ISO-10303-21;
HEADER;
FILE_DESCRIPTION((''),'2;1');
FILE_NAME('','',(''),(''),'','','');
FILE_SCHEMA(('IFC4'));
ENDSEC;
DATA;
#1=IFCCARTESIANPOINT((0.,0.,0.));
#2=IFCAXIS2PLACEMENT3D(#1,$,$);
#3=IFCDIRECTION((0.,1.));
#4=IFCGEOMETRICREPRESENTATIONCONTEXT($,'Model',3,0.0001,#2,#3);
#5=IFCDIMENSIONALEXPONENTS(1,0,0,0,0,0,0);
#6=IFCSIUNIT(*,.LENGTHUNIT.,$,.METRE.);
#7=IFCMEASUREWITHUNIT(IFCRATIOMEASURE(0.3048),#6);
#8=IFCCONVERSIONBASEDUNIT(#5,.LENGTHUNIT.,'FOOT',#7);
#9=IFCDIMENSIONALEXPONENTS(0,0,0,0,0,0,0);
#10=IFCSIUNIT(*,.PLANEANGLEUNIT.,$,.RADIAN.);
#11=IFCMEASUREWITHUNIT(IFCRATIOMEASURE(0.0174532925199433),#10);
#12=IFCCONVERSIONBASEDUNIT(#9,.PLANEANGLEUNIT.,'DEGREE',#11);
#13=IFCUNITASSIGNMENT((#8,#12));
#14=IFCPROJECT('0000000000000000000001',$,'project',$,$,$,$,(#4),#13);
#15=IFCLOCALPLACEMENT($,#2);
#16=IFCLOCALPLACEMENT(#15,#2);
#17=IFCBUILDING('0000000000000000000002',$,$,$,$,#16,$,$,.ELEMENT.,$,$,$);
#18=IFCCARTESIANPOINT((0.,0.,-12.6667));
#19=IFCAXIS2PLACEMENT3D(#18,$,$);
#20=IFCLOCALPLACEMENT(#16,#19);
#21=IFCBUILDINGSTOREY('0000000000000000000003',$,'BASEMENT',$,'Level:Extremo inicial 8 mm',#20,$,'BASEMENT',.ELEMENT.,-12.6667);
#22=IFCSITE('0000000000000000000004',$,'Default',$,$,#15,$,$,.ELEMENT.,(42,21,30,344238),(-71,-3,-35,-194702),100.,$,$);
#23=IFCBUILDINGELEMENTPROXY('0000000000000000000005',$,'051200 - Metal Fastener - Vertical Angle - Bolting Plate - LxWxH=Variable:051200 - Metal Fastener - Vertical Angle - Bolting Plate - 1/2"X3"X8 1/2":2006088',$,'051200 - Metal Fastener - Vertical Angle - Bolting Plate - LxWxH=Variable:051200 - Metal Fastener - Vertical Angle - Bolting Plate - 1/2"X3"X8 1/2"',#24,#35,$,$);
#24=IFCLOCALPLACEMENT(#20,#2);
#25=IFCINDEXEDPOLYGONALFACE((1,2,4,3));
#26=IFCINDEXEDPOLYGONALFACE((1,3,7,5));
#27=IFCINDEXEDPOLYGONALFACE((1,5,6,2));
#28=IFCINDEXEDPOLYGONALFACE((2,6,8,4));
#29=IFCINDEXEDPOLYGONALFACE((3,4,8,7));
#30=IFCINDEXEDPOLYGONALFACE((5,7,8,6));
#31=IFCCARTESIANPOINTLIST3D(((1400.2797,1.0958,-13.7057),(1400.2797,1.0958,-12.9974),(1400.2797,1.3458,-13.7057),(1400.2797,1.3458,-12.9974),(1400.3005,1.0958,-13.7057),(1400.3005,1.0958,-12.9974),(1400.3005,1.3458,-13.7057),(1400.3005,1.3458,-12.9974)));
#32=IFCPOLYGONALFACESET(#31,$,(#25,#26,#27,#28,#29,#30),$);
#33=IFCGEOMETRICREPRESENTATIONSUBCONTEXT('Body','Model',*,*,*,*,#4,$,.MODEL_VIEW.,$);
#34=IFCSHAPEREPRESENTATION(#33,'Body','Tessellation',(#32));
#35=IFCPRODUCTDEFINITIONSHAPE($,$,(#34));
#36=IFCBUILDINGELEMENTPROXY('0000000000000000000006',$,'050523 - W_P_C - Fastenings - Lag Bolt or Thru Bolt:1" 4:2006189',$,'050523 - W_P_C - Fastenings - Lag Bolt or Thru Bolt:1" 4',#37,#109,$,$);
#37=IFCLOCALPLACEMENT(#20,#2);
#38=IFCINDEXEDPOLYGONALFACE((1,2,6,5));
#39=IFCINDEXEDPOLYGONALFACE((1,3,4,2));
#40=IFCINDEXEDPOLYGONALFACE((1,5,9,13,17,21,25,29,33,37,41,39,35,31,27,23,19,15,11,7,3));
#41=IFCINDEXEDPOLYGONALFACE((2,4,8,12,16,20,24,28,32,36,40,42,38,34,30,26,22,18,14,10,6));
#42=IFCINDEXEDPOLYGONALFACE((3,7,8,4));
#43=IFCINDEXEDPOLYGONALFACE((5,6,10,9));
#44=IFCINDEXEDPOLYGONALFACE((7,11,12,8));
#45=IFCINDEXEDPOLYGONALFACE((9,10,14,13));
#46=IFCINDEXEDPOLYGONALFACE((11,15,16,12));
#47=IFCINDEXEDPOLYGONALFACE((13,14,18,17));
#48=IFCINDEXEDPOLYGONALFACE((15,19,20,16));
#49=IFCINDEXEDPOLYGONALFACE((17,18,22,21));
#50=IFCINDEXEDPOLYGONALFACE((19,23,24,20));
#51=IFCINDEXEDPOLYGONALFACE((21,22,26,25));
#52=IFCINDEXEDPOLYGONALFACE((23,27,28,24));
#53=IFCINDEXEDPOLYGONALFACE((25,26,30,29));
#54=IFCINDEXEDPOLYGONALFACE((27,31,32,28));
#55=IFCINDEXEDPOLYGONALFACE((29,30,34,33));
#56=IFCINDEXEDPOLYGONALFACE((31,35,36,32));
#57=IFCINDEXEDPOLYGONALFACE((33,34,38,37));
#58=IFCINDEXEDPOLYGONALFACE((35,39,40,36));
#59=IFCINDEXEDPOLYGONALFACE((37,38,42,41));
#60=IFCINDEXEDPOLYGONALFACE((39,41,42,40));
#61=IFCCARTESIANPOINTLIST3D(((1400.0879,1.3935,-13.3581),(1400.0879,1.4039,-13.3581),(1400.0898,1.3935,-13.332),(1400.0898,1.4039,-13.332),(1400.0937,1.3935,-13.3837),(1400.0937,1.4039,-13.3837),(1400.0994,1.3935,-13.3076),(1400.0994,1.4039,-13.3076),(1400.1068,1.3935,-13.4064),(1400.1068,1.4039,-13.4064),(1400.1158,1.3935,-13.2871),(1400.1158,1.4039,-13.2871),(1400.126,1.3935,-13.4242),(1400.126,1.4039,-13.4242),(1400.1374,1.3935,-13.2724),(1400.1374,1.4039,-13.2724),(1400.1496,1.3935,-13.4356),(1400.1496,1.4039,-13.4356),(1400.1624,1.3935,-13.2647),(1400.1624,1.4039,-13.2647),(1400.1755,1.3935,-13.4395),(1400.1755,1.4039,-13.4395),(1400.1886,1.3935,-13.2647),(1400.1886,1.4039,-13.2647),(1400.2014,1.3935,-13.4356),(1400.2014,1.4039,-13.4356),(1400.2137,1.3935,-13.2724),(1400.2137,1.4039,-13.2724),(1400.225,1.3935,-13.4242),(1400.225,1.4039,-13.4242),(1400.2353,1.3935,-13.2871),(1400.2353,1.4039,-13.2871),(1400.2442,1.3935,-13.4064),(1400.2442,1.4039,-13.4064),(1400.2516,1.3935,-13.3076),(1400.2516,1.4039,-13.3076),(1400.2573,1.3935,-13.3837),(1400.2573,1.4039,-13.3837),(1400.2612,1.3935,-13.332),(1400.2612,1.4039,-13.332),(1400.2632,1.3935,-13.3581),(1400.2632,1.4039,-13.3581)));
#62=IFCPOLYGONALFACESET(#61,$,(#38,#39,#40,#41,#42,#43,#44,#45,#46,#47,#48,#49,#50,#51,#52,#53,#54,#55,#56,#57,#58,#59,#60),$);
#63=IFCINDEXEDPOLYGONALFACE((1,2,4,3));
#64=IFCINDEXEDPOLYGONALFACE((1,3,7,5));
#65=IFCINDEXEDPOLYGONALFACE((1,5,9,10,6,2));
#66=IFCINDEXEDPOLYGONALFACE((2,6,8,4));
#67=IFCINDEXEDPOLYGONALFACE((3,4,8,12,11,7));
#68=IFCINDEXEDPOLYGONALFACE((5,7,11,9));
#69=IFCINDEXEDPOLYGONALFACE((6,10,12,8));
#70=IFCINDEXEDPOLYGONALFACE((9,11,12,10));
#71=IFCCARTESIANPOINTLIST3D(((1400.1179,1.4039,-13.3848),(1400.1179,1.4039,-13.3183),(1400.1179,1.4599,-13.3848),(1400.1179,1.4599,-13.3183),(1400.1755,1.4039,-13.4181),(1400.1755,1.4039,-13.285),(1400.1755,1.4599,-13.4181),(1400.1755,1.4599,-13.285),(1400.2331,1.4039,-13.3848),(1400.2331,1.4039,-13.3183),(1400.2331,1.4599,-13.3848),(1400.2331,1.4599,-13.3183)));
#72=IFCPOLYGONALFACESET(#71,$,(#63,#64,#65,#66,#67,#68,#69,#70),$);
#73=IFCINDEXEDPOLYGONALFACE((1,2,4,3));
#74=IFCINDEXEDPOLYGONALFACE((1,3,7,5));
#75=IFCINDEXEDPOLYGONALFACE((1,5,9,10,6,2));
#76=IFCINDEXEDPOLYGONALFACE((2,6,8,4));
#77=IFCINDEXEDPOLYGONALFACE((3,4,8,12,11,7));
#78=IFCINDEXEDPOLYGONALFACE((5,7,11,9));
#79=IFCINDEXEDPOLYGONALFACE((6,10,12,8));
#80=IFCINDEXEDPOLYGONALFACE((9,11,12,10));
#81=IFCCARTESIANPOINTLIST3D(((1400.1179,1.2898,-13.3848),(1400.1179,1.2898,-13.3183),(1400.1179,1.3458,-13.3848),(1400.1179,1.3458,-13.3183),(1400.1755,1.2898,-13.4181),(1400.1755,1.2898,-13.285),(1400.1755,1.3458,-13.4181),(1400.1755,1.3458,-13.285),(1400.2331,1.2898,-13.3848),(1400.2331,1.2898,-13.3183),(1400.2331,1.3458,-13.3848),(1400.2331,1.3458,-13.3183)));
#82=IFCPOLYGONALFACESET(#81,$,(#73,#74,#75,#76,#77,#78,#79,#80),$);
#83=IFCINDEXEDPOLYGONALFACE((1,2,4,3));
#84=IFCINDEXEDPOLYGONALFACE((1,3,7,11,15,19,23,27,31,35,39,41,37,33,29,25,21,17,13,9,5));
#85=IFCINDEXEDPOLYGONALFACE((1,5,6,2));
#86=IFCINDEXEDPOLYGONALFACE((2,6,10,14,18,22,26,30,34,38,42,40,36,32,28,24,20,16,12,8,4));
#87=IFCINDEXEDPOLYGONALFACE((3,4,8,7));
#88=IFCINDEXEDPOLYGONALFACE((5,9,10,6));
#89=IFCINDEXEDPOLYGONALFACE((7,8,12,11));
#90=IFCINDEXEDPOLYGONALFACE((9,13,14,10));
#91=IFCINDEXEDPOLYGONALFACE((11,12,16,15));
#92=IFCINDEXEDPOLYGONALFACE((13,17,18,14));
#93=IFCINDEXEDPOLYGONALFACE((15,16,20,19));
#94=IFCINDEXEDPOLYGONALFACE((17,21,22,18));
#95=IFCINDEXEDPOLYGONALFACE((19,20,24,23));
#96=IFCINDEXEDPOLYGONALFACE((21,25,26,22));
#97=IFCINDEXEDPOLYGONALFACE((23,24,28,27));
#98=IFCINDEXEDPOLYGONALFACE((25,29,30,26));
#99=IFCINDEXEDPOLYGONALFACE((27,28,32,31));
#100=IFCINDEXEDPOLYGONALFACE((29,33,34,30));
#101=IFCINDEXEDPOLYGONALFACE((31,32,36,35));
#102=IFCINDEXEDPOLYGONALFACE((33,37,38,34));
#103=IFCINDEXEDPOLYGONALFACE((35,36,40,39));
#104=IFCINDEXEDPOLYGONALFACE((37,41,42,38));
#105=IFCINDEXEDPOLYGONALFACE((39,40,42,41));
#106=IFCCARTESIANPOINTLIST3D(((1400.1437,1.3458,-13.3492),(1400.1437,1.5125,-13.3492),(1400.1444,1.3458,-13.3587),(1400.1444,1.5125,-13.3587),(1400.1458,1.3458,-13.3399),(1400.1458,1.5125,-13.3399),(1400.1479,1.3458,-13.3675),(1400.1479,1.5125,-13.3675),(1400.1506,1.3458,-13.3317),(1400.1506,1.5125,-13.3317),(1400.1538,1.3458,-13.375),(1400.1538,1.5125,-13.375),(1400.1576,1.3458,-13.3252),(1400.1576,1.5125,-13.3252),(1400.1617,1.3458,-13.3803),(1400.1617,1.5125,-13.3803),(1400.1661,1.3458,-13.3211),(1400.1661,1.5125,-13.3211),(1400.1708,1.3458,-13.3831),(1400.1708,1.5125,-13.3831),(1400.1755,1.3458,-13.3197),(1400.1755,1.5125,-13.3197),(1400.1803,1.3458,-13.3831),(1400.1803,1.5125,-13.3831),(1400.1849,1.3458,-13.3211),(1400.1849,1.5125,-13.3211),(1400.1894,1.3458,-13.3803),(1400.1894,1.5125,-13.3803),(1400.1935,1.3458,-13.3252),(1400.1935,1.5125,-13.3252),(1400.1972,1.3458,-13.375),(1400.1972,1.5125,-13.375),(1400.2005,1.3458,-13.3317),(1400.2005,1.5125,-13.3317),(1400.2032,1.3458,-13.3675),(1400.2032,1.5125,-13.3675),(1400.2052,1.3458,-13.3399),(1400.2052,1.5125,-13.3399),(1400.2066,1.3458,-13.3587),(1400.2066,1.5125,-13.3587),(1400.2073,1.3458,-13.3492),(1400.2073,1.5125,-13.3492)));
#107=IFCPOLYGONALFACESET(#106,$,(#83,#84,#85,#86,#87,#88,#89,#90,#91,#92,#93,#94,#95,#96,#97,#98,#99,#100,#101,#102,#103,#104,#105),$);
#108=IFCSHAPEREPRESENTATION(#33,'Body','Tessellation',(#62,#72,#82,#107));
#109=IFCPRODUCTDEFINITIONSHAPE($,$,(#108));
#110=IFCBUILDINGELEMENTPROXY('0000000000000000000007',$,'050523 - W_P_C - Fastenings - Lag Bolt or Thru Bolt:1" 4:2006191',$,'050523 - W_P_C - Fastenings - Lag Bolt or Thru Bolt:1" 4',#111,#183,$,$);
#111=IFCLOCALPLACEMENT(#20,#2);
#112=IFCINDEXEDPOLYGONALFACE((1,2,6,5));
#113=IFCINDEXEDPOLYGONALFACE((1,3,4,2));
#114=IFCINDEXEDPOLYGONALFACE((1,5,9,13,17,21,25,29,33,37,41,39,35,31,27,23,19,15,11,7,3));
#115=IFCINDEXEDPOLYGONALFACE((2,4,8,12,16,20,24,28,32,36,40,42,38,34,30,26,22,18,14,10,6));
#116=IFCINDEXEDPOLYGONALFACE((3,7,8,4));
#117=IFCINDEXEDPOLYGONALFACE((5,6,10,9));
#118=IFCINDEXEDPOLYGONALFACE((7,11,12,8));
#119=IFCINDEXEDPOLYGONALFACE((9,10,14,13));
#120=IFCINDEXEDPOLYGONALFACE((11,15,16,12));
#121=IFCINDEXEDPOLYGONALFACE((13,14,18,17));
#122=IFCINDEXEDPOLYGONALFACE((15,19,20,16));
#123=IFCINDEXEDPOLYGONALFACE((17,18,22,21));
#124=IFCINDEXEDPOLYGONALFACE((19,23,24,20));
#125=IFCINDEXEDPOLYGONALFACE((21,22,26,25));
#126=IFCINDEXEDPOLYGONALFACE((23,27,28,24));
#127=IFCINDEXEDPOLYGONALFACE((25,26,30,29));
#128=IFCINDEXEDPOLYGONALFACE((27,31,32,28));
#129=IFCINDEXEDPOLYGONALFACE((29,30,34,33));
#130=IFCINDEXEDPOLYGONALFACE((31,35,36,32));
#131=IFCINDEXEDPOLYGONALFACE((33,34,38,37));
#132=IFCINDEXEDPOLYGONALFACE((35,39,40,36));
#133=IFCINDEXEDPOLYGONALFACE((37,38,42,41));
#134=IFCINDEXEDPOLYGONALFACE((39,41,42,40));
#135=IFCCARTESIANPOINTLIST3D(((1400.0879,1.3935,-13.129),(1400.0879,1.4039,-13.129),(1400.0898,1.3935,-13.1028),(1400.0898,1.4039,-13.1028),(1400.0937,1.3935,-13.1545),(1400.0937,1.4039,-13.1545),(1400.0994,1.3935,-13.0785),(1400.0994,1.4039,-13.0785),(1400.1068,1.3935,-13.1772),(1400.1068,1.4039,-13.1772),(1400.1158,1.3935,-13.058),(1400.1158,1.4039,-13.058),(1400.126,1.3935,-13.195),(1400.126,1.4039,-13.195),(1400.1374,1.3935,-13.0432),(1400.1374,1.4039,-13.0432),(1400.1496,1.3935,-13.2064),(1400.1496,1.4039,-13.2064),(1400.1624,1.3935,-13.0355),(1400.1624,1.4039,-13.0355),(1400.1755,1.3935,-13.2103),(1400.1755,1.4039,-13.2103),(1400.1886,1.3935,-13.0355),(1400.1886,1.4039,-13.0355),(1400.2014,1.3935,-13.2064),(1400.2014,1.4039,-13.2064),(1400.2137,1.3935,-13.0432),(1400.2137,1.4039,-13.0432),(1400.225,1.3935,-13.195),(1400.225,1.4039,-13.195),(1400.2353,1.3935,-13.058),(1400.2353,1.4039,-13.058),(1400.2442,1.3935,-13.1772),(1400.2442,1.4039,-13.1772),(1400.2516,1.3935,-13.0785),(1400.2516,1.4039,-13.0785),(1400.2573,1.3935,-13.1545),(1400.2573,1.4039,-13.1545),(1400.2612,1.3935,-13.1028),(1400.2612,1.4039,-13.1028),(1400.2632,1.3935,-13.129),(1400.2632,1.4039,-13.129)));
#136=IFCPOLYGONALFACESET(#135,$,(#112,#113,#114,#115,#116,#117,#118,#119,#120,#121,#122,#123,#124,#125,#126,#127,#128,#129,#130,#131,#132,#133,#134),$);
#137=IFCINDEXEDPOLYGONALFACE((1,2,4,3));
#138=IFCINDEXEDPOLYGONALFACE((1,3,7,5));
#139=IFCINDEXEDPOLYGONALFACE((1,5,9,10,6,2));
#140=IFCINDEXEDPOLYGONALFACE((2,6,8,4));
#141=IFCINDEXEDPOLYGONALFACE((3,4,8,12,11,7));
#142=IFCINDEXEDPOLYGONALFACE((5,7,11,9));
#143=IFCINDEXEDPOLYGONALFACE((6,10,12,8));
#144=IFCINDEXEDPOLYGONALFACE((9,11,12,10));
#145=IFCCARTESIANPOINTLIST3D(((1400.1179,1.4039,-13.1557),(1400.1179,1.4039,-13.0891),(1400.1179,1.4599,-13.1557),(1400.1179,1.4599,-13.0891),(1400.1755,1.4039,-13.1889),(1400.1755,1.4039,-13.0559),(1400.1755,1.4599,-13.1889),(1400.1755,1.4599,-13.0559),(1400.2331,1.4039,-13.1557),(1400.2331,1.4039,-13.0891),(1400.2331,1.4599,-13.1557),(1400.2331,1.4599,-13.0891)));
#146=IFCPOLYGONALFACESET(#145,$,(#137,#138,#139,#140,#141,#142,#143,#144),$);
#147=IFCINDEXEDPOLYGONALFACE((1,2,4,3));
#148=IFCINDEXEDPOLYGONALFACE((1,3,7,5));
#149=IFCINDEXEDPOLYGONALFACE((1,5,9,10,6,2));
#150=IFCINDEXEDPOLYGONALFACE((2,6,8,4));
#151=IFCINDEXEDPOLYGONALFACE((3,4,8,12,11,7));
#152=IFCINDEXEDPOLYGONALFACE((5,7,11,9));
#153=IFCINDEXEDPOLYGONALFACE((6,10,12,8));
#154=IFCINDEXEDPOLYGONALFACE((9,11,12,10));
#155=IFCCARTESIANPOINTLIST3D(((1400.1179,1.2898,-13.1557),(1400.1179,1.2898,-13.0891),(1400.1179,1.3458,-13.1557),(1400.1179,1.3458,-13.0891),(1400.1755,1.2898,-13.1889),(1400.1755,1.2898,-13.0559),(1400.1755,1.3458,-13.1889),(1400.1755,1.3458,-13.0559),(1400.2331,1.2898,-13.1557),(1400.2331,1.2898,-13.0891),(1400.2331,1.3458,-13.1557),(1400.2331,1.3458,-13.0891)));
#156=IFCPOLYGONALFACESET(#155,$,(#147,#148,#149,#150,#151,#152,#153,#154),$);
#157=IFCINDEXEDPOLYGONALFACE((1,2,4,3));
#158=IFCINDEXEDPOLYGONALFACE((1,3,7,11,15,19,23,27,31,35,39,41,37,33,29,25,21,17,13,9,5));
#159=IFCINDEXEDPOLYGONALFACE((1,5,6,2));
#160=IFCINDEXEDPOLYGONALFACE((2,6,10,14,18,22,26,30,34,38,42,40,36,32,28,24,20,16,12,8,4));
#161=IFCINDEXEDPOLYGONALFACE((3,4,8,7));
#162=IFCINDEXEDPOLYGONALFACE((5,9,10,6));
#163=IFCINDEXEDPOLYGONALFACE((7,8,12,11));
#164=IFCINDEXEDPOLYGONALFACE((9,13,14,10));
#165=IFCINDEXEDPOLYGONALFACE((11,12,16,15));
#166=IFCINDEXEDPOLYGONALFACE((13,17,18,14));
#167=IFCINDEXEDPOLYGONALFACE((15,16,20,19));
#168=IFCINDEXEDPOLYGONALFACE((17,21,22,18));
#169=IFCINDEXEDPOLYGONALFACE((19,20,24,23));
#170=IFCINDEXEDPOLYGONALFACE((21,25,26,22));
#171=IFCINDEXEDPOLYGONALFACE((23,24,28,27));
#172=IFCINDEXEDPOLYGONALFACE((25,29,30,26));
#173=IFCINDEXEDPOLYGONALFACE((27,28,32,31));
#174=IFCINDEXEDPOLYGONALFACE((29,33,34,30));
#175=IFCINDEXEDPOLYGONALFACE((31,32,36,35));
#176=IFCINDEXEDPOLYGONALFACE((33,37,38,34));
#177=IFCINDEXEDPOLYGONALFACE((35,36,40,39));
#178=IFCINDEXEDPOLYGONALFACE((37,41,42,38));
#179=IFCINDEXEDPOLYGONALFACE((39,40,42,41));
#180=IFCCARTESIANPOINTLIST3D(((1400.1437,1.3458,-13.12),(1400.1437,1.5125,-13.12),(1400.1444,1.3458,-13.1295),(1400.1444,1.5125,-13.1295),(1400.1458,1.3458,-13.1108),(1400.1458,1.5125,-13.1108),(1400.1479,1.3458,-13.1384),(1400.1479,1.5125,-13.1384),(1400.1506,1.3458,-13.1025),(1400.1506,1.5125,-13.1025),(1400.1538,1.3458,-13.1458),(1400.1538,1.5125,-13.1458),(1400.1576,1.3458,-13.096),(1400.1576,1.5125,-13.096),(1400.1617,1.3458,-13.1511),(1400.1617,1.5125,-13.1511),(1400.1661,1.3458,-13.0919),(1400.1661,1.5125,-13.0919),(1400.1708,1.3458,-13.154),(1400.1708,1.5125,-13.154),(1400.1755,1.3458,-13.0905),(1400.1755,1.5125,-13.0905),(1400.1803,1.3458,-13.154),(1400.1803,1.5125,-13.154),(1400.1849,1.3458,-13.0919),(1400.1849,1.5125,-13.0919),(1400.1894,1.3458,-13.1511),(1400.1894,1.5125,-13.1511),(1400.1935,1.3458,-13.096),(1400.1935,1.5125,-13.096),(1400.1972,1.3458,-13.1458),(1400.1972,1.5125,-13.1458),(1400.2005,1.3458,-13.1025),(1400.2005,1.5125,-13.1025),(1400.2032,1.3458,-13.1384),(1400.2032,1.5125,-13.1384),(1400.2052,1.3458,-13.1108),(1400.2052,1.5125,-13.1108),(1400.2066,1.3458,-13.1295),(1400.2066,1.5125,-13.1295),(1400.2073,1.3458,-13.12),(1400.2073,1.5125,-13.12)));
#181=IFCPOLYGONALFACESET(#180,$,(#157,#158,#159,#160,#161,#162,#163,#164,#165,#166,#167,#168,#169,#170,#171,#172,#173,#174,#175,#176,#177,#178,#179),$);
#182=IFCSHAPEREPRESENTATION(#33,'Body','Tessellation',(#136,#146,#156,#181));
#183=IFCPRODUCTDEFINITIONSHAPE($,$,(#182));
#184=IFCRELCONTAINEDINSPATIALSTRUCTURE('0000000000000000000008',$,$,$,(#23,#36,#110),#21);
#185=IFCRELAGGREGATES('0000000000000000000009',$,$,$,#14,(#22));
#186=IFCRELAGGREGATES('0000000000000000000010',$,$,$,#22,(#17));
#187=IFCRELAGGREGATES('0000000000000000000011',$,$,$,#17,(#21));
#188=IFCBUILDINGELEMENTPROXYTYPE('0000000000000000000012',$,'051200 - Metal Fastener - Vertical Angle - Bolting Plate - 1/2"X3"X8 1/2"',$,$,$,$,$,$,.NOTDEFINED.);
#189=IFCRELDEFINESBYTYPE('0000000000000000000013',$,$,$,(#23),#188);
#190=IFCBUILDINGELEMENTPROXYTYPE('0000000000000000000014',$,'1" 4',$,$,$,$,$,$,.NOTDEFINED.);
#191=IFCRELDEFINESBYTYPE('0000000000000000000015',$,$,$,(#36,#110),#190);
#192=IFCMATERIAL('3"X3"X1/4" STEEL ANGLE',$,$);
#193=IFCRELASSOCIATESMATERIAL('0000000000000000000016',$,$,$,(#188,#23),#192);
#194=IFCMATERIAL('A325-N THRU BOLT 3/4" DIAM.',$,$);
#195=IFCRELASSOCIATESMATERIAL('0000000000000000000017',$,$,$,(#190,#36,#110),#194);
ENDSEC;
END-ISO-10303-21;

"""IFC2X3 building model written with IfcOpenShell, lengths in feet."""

from ifc_helpers import new_model, entity, si_unit, converted_unit, direction, frame, frame_2d, origin, origin_2d_with_axis, place, context, subcontext, project, spatial, polyline, rectangle, circle, outline, extrude, source, transform, mapped, material, type_object, type_shapes, element, save


model = new_model("IFC2X3")

# Units and contexts
model_context = context("Model", 3, precision=0.0001, world=origin(), true_north=direction((0.0, 1.0)))
body_context = subcontext(model_context, "Body", "Model", "MODEL_VIEW")
ifc_project = project(units=[converted_unit("LENGTHUNIT", "FOOT", entity("IfcRatioMeasure", 0.3048), si_unit("LENGTHUNIT", "METRE"), dimensions=[1, 0, 0, 0, 0, 0, 0]), converted_unit("PLANEANGLEUNIT", "DEGREE", entity("IfcRatioMeasure", 0.0174532925199433), si_unit("PLANEANGLEUNIT", "RADIAN"), dimensions=[0, 0, 0, 0, 0, 0, 0])], contexts=[model_context])

# Site, building, storey
site_placement = place(None, origin())
site = spatial("IfcSite", under=ifc_project, at=site_placement, Name="Default", CompositionType="ELEMENT", RefLatitude=(42, 21, 30, 344238), RefLongitude=(-71, -3, -35, -194702), RefElevation=100.0)
building_placement = place(site_placement, origin())
building = spatial("IfcBuilding", under=site, at=building_placement, CompositionType="ELEMENT")
storey_placement = place(building_placement, frame((0.0, 0.0, -12.6667)))
storey = spatial("IfcBuildingStorey", under=building, at=storey_placement, Name="BASEMENT", ObjectType="Level:Extremo inicial 8 mm", LongName="BASEMENT", CompositionType="ELEMENT", Elevation=-12.6667)

# Building element proxies
ifc_material_1 = material(Name="3\"X3\"X1/4\" STEEL ANGLE")
building_element_proxy_type_1 = type_object("IfcBuildingElementProxyType", Name="051200 - Metal Fastener - Vertical Angle - Bolting Plate - 1/2\"X3\"X8 1/2\"", PredefinedType="NOTDEFINED", material=ifc_material_1)
shared_shape_1 = source(origin(), body_context, "Body", "SweptSolid", [
    extrude(rectangle(XDim=0.25, YDim=0.7083, at=origin_2d_with_axis()), frame((0.0, 0.0, 0.0), z_axis=(0.0, 0.0, 1.0), x_axis=(-1.0, 0.0, 0.0)), (0.0, 0.0, 1.0), 0.0208),
])
type_shapes(building_element_proxy_type_1, [shared_shape_1])
for number, where, z_axis, x_axis, name in (
    (1, (1400.3005, 1.2208, -13.3516), (-1.0, 0.0, 0.0), (0.0, -1.0, 0.0), "051200 - Metal Fastener - Vertical Angle - Bolting Plate - LxWxH=Variable:051200 - Metal Fastener - Vertical Angle - Bolting Plate - 1/2\"X3\"X8 1/2\":2006088"),
):
    element("IfcBuildingElementProxy", number, at=place(storey_placement, frame(where, z_axis=z_axis, x_axis=x_axis)), inside=storey, type_object=building_element_proxy_type_1, material=ifc_material_1, Name=name, ObjectType="051200 - Metal Fastener - Vertical Angle - Bolting Plate - LxWxH=Variable:051200 - Metal Fastener - Vertical Angle - Bolting Plate - 1/2\"X3\"X8 1/2\"", context=body_context, shape_type="MappedRepresentation", body=[
        mapped(shared_shape_1, transform((0.0, 0.0, 0.0), scale=1.0)),
    ])
ifc_material_2 = material(Name="A325-N THRU BOLT 3/4\" DIAM.")
building_element_proxy_type_2 = type_object("IfcBuildingElementProxyType", Name="1\" 4", PredefinedType="NOTDEFINED", material=ifc_material_2)
shared_shape_2 = source(origin(), body_context, "Body", "SweptSolid", [
    extrude(circle(Radius=0.0879, at=frame_2d((0.0, 0.0), x_axis=(1.0, 0.0))), frame((0.0, 0.0, -0.0581), z_axis=(0.0, 0.0, 1.0), x_axis=(0.0, -1.0, 0.0)), (0.0, 0.0, 1.0), 0.0104),
    extrude(outline(polyline([(-0.0333, -0.0576), (0.0333, -0.0576), (0.0665, 0.0), (0.0333, 0.0576), (-0.0333, 0.0576), (-0.0665, 0.0), (-0.0333, -0.0576)])), frame((0.0, 0.0, -0.1141), z_axis=(0.0, 0.0, 1.0), x_axis=(0.866025, -0.5, 0.0)), (0.0, 0.0, 1.0), 0.056),
    extrude(outline(polyline([(-0.0333, -0.0576), (0.0333, -0.0576), (0.0665, 0.0), (0.0333, 0.0576), (-0.0333, 0.0576), (-0.0665, 0.0), (-0.0333, -0.0576)])), frame((0.0, 0.0, 0.0), z_axis=(0.0, 0.0, 1.0), x_axis=(0.0, -1.0, 0.0)), (0.0, 0.0, 1.0), 0.056),
    extrude(circle(Radius=0.0319, at=frame_2d((0.0, 0.0), x_axis=(1.0, 0.0))), frame((0.0, 0.0, -0.1667), z_axis=(0.0, 0.0, 1.0), x_axis=(0.0, 1.0, 0.0)), (0.0, 0.0, 1.0), 0.1667),
])
type_shapes(building_element_proxy_type_2, [shared_shape_2])
for number, where, z_axis, x_axis, name in (
    (2, (1400.1755, 1.3458, -13.3516), (0.0, -1.0, 0.0), (1.0, 0.0, 0.0), "050523 - W_P_C - Fastenings - Lag Bolt or Thru Bolt:1\" 4:2006189"),
    (3, (1400.1755, 1.3458, -13.1224), (0.0, -1.0, 0.0), (1.0, 0.0, 0.0), "050523 - W_P_C - Fastenings - Lag Bolt or Thru Bolt:1\" 4:2006191"),
):
    element("IfcBuildingElementProxy", number, at=place(storey_placement, frame(where, z_axis=z_axis, x_axis=x_axis)), inside=storey, type_object=building_element_proxy_type_2, material=ifc_material_2, Name=name, ObjectType="050523 - W_P_C - Fastenings - Lag Bolt or Thru Bolt:1\" 4", context=body_context, shape_type="MappedRepresentation", body=[
        mapped(shared_shape_2, transform((0.0, 0.0, 0.0), scale=1.0)),
    ])

save(model, "model.ifc")
